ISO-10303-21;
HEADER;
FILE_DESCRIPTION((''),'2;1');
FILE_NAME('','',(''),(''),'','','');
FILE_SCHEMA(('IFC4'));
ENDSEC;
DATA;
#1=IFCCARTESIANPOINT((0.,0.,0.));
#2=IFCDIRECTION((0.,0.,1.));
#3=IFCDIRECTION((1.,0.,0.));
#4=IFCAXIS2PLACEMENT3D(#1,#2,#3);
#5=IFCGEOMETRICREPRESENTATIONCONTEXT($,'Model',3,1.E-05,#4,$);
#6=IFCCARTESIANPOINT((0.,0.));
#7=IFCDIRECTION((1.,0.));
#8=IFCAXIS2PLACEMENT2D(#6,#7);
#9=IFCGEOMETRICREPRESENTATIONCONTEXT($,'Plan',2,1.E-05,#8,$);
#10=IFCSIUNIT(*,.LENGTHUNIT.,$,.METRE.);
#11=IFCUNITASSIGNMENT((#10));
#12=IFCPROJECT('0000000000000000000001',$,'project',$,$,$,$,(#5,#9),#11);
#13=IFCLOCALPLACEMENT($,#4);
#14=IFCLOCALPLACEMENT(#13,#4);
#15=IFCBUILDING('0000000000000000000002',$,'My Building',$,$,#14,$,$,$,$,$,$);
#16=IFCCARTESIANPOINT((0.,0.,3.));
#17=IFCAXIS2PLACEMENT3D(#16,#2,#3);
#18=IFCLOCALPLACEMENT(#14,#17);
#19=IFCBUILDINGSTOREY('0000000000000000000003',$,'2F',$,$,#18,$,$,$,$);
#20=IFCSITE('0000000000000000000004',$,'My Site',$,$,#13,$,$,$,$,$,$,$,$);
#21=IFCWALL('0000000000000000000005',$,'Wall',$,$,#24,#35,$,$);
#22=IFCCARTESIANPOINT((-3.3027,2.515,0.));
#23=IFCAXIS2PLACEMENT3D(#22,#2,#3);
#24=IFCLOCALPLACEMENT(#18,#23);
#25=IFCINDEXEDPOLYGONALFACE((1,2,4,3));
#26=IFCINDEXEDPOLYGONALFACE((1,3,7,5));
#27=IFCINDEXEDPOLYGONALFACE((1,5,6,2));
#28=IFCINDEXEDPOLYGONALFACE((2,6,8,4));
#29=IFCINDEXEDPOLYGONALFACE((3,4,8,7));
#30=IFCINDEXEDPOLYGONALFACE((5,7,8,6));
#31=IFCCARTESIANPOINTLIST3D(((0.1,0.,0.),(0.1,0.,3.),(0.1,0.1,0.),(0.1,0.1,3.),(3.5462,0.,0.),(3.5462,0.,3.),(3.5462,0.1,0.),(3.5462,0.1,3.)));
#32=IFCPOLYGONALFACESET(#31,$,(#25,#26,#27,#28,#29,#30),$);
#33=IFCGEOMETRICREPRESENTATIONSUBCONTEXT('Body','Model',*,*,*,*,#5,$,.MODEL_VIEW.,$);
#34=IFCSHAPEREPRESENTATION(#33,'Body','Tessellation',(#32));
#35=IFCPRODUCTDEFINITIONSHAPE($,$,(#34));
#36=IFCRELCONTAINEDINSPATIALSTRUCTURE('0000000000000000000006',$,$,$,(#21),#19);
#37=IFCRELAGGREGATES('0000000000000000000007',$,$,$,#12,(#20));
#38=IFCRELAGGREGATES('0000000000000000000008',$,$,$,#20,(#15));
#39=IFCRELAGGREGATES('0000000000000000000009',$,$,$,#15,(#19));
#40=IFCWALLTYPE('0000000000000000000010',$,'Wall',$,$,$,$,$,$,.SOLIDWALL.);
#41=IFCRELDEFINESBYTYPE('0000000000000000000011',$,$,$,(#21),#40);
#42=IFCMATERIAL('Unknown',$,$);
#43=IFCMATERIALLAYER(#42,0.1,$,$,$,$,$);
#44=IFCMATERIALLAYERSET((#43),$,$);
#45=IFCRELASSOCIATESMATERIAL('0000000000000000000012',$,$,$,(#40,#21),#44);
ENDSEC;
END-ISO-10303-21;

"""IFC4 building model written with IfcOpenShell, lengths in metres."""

from ifc_helpers import new_model, si_unit, frame, origin_with_axes, origin_2d_with_axis, place, context, subcontext, project, spatial, line, indexed_curve, outline, extrude, material, layer, layer_set, layer_usage, type_object, element, save


model = new_model("IFC4")

# Units and contexts
model_context = context("Model", 3, precision=1e-05, world=origin_with_axes())
plan_context = context("Plan", 2, precision=1e-05, world=origin_2d_with_axis())
body_context_1 = subcontext(model_context, "Body", "Model", "MODEL_VIEW")
ifc_project = project(units=[si_unit("LENGTHUNIT", "METRE")], contexts=[model_context, plan_context])

# Site, building, storey
site_placement = place(None, origin_with_axes())
site = spatial("IfcSite", under=ifc_project, at=site_placement, Name="My Site")
building_placement = place(site_placement, origin_with_axes())
building = spatial("IfcBuilding", under=site, at=building_placement, Name="My Building")
storey_placement = place(building_placement, frame((0.0, 0.0, 3.0), z_axis=(0.0, 0.0, 1.0), x_axis=(1.0, 0.0, 0.0)))
storey = spatial("IfcBuildingStorey", under=building, at=storey_placement, Name="2F")

# Shared definitions
ifc_material = material(Name="Unknown")

# Shared definitions
ifc_layer_1 = layer(ifc_material, 0.1)
ifc_layer_set_1 = layer_set([ifc_layer_1])
wall_type = type_object("IfcWallType", Name="Wall", PredefinedType="SOLIDWALL", material=ifc_layer_set_1)

# Wall
ifc_layer_usage_1 = layer_usage(ifc_layer_set_1, "AXIS2", "POSITIVE", 0.0)
wall_1_placement = place(storey_placement, frame((-3.3027, 2.515, 0.0), z_axis=(0.0, 0.0, 1.0), x_axis=(1.0, 0.0, 0.0)))
element("IfcWall", 1, at=wall_1_placement, inside=storey, type_object=wall_type, material=ifc_layer_usage_1, Name="Wall", context=body_context_1, shape_type="SweptSolid", body=[
    extrude(outline(indexed_curve([(0.1, 0.0), (0.1, 0.1), (3.5462, 0.1), (3.5462, 0.0)], segments=[line(1, 2, 3, 4, 1)])), origin_with_axes(), (0.0, 0.0, 1.0), 3.0),
])

save(model, "model.ifc")
